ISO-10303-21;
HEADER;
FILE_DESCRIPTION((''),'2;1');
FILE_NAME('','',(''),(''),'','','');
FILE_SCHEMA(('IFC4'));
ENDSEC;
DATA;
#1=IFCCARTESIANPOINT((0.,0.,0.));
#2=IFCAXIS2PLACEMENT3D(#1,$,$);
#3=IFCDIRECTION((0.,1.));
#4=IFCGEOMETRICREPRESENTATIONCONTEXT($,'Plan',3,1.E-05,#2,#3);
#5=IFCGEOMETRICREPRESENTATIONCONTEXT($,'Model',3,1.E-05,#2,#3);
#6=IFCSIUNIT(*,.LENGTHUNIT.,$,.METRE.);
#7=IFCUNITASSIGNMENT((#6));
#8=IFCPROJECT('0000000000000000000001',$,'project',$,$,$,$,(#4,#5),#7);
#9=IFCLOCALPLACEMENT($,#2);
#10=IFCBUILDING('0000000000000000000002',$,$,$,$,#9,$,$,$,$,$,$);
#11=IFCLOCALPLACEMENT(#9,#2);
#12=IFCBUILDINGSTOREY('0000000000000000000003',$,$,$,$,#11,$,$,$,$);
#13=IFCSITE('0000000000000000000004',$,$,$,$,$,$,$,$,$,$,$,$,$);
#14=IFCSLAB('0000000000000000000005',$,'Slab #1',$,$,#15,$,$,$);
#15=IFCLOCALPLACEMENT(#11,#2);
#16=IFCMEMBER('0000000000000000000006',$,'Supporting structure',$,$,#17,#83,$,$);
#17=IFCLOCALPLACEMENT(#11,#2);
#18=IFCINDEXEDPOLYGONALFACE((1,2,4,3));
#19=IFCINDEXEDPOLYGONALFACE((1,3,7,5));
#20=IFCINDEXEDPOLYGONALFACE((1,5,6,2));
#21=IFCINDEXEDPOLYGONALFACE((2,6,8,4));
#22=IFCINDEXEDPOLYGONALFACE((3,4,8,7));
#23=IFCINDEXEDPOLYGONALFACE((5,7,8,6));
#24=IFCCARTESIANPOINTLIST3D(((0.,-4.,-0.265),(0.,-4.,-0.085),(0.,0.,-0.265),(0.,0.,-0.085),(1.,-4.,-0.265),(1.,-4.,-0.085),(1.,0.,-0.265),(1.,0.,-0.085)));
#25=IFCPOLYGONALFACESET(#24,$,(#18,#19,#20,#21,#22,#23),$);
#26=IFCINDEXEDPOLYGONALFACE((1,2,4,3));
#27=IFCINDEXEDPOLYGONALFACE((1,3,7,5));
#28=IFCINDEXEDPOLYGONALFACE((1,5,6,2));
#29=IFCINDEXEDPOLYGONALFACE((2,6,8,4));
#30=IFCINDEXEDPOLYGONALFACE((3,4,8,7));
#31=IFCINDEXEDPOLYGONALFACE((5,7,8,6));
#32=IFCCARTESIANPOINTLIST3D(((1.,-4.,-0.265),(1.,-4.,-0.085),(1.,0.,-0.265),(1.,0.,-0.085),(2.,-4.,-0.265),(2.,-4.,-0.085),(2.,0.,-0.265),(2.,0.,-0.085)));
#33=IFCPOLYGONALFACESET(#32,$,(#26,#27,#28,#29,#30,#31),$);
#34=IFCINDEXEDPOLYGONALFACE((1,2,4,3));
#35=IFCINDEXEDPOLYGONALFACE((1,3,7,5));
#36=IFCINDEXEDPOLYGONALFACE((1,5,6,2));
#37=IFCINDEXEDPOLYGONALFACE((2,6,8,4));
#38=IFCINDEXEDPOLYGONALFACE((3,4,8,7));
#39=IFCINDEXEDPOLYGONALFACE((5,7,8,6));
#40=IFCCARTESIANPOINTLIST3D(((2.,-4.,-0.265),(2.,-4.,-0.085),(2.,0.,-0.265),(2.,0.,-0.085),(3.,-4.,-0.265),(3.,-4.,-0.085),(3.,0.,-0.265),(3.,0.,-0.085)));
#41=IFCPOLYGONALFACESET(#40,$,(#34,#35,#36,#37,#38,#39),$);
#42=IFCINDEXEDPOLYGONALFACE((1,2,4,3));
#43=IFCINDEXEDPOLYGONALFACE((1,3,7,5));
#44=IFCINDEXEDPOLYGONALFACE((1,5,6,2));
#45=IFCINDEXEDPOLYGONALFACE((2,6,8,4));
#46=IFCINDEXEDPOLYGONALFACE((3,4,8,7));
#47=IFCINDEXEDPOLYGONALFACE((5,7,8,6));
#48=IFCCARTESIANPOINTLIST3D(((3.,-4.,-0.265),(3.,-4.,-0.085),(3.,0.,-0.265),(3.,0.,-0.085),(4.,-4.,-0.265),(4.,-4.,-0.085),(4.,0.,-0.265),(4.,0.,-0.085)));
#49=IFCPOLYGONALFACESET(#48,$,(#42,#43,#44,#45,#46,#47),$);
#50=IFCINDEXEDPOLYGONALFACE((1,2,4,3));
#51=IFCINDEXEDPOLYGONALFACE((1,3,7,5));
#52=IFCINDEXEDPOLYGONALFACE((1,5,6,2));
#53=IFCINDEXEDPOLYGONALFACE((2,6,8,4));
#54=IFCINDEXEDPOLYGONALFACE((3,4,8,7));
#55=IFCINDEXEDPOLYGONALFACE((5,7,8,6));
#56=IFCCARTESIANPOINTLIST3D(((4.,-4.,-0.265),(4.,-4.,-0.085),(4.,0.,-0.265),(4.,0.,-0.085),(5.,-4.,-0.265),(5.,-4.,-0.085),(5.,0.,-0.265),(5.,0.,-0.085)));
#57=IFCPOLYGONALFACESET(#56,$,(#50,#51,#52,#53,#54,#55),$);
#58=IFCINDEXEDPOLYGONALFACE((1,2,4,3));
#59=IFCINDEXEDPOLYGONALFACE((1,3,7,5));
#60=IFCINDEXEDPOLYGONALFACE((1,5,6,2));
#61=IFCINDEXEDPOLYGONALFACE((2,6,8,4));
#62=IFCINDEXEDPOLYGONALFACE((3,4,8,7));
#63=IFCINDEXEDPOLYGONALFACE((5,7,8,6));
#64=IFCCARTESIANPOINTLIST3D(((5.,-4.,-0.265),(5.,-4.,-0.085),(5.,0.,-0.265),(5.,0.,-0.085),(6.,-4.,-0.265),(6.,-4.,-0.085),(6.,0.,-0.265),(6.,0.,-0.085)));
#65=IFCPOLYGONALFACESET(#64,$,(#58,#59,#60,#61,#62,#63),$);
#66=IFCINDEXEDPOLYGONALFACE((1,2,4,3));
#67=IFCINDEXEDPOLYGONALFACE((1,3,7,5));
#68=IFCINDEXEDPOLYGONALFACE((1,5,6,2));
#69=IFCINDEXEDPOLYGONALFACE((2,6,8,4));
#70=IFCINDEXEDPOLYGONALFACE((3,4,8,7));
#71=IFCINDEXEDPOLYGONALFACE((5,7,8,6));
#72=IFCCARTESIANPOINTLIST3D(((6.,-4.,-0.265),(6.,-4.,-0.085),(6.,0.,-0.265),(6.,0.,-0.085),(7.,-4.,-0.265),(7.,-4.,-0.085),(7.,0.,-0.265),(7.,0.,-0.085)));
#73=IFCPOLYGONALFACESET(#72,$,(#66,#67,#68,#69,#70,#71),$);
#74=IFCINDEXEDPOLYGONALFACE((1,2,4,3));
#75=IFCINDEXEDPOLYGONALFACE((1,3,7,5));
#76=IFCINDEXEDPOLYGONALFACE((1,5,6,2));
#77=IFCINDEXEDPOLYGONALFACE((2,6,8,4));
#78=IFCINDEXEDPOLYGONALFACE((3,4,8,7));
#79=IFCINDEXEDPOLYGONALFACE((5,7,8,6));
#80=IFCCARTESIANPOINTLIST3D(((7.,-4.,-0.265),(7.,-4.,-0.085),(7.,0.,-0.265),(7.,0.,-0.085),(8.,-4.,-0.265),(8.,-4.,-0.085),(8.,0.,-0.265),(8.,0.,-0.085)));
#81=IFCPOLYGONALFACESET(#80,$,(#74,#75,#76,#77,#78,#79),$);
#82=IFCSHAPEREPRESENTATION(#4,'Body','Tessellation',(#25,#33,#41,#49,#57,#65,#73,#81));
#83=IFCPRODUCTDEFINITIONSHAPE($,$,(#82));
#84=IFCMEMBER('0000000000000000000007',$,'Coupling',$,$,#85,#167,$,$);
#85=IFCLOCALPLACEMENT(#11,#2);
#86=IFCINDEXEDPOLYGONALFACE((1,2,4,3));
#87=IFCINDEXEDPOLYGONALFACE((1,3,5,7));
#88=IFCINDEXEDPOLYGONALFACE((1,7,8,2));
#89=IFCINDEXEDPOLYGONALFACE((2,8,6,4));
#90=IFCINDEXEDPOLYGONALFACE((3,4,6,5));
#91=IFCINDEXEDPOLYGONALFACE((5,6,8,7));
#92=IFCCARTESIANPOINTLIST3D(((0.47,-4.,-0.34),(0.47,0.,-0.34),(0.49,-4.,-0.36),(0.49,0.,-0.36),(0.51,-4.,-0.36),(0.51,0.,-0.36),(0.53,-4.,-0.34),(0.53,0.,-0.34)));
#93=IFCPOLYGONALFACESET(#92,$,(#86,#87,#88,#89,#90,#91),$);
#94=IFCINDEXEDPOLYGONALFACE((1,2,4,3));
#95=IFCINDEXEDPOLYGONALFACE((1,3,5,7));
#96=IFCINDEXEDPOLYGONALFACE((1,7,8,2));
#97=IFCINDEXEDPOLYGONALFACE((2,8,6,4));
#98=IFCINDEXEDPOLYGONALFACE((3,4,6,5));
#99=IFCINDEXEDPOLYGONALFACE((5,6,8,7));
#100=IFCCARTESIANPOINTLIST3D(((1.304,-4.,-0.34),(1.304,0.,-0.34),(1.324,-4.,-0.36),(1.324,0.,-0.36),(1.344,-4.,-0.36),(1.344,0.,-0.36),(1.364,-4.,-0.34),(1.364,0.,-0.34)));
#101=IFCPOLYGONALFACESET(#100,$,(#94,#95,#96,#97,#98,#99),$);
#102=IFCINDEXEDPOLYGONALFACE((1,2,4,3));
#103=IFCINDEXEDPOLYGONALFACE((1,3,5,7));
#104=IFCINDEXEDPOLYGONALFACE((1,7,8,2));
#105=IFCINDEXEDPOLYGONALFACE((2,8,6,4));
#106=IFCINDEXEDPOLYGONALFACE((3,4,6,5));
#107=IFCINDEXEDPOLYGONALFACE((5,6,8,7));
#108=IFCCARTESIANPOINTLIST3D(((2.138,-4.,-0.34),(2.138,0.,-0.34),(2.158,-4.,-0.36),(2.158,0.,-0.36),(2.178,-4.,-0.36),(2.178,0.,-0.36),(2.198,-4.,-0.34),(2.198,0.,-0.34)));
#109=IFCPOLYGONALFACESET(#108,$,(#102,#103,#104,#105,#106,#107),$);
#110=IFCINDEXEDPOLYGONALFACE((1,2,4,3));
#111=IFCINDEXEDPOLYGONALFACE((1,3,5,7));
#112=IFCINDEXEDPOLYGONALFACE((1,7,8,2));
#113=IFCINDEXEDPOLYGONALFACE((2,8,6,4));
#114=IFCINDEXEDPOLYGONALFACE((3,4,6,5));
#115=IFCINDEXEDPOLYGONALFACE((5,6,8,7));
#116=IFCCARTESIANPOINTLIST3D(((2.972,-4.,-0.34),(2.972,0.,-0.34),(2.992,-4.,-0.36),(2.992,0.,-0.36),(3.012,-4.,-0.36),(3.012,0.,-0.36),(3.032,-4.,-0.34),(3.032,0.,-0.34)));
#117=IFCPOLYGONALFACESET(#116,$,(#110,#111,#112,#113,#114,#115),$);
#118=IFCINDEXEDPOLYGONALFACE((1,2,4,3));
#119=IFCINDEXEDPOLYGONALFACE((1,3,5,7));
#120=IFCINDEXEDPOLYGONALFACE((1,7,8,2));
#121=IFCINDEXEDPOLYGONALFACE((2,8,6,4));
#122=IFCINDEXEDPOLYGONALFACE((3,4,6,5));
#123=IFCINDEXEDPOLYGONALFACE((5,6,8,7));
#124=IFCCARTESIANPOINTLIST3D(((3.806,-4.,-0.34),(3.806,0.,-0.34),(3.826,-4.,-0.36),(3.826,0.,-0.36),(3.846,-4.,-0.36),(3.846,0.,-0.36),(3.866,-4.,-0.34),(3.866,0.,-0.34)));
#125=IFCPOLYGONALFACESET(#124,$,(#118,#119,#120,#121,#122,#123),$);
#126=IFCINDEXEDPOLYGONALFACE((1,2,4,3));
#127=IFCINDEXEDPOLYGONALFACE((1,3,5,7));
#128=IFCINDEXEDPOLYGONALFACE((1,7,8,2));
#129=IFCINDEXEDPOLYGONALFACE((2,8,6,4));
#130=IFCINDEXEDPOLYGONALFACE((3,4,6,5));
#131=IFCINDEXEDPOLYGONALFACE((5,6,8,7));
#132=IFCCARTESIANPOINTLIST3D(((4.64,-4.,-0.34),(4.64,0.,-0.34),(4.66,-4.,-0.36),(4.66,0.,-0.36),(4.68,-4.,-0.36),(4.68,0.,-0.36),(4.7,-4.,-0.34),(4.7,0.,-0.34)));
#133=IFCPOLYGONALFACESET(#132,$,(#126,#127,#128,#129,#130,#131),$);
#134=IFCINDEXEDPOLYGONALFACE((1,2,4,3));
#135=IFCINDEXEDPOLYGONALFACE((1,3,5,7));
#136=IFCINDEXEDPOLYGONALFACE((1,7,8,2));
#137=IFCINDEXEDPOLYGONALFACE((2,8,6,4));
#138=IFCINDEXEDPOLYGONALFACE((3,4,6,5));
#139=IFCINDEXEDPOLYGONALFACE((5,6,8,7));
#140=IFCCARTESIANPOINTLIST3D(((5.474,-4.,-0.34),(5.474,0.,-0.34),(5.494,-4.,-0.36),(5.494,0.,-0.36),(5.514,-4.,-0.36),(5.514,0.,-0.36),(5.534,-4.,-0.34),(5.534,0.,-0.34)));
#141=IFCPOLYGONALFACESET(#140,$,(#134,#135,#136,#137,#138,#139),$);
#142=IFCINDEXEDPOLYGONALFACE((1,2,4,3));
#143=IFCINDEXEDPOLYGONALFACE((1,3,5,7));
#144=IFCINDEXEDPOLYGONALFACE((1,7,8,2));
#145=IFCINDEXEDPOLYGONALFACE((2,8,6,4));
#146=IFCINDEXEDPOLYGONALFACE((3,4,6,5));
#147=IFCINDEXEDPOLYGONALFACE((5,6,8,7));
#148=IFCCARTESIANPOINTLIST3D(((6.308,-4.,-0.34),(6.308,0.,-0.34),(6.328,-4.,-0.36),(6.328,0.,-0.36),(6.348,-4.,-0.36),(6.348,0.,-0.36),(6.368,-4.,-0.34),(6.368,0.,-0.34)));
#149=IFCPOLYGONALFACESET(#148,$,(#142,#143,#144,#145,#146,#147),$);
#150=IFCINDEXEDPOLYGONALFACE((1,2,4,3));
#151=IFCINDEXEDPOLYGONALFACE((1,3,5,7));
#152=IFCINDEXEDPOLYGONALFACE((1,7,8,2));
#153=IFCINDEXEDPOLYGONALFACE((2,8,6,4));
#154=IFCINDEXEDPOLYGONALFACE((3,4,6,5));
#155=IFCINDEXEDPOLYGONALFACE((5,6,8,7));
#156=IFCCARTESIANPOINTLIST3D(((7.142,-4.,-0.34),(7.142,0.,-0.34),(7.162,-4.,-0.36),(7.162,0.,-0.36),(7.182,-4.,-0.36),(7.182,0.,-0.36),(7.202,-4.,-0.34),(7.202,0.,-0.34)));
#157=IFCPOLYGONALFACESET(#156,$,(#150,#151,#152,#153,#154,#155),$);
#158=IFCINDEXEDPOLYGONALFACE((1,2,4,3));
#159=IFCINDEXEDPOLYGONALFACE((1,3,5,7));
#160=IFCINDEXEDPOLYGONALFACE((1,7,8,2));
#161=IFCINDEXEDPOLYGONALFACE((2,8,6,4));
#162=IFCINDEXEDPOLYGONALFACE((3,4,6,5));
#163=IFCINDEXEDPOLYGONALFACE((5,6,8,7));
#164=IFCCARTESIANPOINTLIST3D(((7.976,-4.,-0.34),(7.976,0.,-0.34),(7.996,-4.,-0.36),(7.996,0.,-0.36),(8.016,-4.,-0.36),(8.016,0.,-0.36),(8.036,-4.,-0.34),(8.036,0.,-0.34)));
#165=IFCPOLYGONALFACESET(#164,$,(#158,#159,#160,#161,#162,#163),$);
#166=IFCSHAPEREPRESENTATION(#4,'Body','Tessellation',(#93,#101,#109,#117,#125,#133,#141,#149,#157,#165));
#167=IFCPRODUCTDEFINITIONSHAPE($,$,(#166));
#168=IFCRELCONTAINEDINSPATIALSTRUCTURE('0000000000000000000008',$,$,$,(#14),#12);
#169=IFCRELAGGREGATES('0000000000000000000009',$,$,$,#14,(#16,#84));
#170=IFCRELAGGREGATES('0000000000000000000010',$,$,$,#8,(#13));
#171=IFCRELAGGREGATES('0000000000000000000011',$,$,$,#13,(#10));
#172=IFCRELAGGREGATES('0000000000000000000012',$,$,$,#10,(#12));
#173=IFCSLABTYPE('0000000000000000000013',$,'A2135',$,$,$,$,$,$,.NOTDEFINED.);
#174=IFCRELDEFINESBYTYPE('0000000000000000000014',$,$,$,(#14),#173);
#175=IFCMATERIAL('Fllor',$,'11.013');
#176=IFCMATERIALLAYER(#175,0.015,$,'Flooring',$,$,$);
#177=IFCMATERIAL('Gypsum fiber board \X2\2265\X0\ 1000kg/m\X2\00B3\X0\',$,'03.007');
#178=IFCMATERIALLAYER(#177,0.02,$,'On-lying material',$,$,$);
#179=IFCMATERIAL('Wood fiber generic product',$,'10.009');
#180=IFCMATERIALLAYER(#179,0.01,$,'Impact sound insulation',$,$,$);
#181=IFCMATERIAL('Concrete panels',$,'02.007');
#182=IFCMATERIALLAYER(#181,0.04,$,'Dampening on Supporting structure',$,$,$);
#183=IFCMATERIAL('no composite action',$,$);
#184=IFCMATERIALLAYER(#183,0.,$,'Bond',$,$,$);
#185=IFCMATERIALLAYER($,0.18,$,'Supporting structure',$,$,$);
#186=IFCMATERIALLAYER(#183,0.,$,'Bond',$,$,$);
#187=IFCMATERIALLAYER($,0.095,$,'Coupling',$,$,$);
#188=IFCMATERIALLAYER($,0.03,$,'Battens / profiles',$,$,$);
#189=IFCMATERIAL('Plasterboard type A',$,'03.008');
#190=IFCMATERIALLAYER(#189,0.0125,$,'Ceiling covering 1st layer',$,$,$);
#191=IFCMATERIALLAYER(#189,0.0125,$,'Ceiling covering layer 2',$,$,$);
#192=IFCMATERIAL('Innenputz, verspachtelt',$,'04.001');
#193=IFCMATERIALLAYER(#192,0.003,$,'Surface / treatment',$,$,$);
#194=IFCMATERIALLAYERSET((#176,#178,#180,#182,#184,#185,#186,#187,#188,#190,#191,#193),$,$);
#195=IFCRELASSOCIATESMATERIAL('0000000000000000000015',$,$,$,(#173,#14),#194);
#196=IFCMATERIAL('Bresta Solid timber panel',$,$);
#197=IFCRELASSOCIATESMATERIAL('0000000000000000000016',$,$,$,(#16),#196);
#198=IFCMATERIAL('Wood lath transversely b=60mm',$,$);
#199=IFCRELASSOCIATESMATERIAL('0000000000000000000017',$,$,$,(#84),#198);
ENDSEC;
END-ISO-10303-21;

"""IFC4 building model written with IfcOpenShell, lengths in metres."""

from ifc_helpers import new_model, si_unit, direction, frame, frame_2d, origin, place, context, project, spatial, polyline, rectangle, outline, extrude, material, layer, layer_set, type_object, element, aggregate, save


model = new_model("IFC4")

# Units and contexts
plan_context = context("Plan", 3, precision=1e-05, world=origin(), true_north=direction((0.0, 1.0)))
model_context = context("Model", 3, precision=1e-05, world=origin(), true_north=direction((0.0, 1.0)))
ifc_project = project(units=[si_unit("LENGTHUNIT", "METRE")], contexts=[plan_context, model_context])

# Site, building, storey
site = spatial("IfcSite", under=ifc_project)
building_placement = place(None, origin())
building = spatial("IfcBuilding", under=site, at=building_placement)
storey_placement = place(building_placement, origin())
storey = spatial("IfcBuildingStorey", under=building, at=storey_placement)

# Slab, members
ifc_material_1 = material(Name="Fllor", Category="11.013")
ifc_layer_1 = layer(ifc_material_1, 0.015, Name="Flooring")
ifc_material_2 = material(Name="Gypsum fiber board ≥ 1000kg/m³", Category="03.007")
ifc_layer_2 = layer(ifc_material_2, 0.02, Name="On-lying material")
ifc_material_3 = material(Name="Wood fiber generic product", Category="10.009")
ifc_layer_3 = layer(ifc_material_3, 0.01, Name="Impact sound insulation")
ifc_material_4 = material(Name="Concrete panels", Category="02.007")
ifc_layer_4 = layer(ifc_material_4, 0.04, Name="Dampening on Supporting structure")
ifc_material_5 = material(Name="no composite action")
ifc_layer_5 = layer(ifc_material_5, 0.0, Name="Bond")
ifc_layer_6 = layer(None, 0.18, Name="Supporting structure")
ifc_layer_7 = layer(ifc_material_5, 0.0, Name="Bond")
ifc_layer_8 = layer(None, 0.095, Name="Coupling")
ifc_layer_9 = layer(None, 0.03, Name="Battens / profiles")
ifc_material_6 = material(Name="Plasterboard type A", Category="03.008")
ifc_layer_10 = layer(ifc_material_6, 0.0125, Name="Ceiling covering 1st layer")
ifc_layer_11 = layer(ifc_material_6, 0.0125, Name="Ceiling covering layer 2")
ifc_material_7 = material(Name="Innenputz, verspachtelt", Category="04.001")
ifc_layer_12 = layer(ifc_material_7, 0.003, Name="Surface / treatment")
ifc_layer_set = layer_set([ifc_layer_1, ifc_layer_2, ifc_layer_3, ifc_layer_4, ifc_layer_5, ifc_layer_6, ifc_layer_7, ifc_layer_8, ifc_layer_9, ifc_layer_10, ifc_layer_11, ifc_layer_12])
slab_type = type_object("IfcSlabType", Name="A2135", PredefinedType="NOTDEFINED", material=ifc_layer_set)
slab_placement = place(None, frame((0.0, 0.0, 0.0), z_axis=(0.0, 0.0, -1.0), x_axis=(1.0, 0.0, 0.0)))
slab = element("IfcSlab", 1, at=slab_placement, inside=storey, type_object=slab_type, material=ifc_layer_set, Name="Slab #1")
ifc_material_8 = material(Name="Bresta Solid timber panel")
member_1_placement = place(slab_placement, origin())
member_1 = element("IfcMember", 2, at=member_1_placement, material=ifc_material_8, Name="Supporting structure", context=plan_context, shape_type="SweptSolid", body=[
    extrude(rectangle(XDim=1.0, YDim=0.18, at=frame_2d((0.5, 0.09), x_axis=(1.0, 0.0))), frame((0.0, 4.0, 0.085), z_axis=(0.0, -1.0, 0.0), x_axis=(1.0, 0.0, 0.0)), (0.0, 0.0, 1.0), 4.0),
    extrude(rectangle(XDim=1.0, YDim=0.18, at=frame_2d((0.5, 0.09), x_axis=(1.0, 0.0))), frame((1.0, 4.0, 0.085), z_axis=(0.0, -1.0, 0.0), x_axis=(1.0, 0.0, 0.0)), (0.0, 0.0, 1.0), 4.0),
    extrude(rectangle(XDim=1.0, YDim=0.18, at=frame_2d((0.5, 0.09), x_axis=(1.0, 0.0))), frame((2.0, 4.0, 0.085), z_axis=(0.0, -1.0, 0.0), x_axis=(1.0, 0.0, 0.0)), (0.0, 0.0, 1.0), 4.0),
    extrude(rectangle(XDim=1.0, YDim=0.18, at=frame_2d((0.5, 0.09), x_axis=(1.0, 0.0))), frame((3.0, 4.0, 0.085), z_axis=(0.0, -1.0, 0.0), x_axis=(1.0, 0.0, 0.0)), (0.0, 0.0, 1.0), 4.0),
    extrude(rectangle(XDim=1.0, YDim=0.18, at=frame_2d((0.5, 0.09), x_axis=(1.0, 0.0))), frame((4.0, 4.0, 0.085), z_axis=(0.0, -1.0, 0.0), x_axis=(1.0, 0.0, 0.0)), (0.0, 0.0, 1.0), 4.0),
    extrude(rectangle(XDim=1.0, YDim=0.18, at=frame_2d((0.5, 0.09), x_axis=(1.0, 0.0))), frame((5.0, 4.0, 0.085), z_axis=(0.0, -1.0, 0.0), x_axis=(1.0, 0.0, 0.0)), (0.0, 0.0, 1.0), 4.0),
    extrude(rectangle(XDim=1.0, YDim=0.18, at=frame_2d((0.5, 0.09), x_axis=(1.0, 0.0))), frame((6.0, 4.0, 0.085), z_axis=(0.0, -1.0, 0.0), x_axis=(1.0, 0.0, 0.0)), (0.0, 0.0, 1.0), 4.0),
    extrude(rectangle(XDim=1.0, YDim=0.18, at=frame_2d((0.5, 0.09), x_axis=(1.0, 0.0))), frame((7.0, 4.0, 0.085), z_axis=(0.0, -1.0, 0.0), x_axis=(1.0, 0.0, 0.0)), (0.0, 0.0, 1.0), 4.0),
])
ifc_material_9 = material(Name="Wood lath transversely b=60mm")
member_2_placement = place(slab_placement, origin())
member_2 = element("IfcMember", 3, at=member_2_placement, material=ifc_material_9, Name="Coupling", context=plan_context, shape_type="SweptSolid", body=[
    extrude(outline(polyline([(0.0, 0.0), (0.06, 0.0), (0.04, 0.02), (0.02, 0.02), (0.0, 0.0)])), frame((0.47, 4.0, 0.34), z_axis=(0.0, -1.0, 0.0), x_axis=(1.0, 0.0, 0.0)), (0.0, 0.0, 1.0), 4.0),
    extrude(outline(polyline([(0.0, 0.0), (0.06, 0.0), (0.04, 0.02), (0.02, 0.02), (0.0, 0.0)])), frame((1.304, 4.0, 0.34), z_axis=(0.0, -1.0, 0.0), x_axis=(1.0, 0.0, 0.0)), (0.0, 0.0, 1.0), 4.0),
    extrude(outline(polyline([(0.0, 0.0), (0.06, 0.0), (0.04, 0.02), (0.02, 0.02), (0.0, 0.0)])), frame((2.138, 4.0, 0.34), z_axis=(0.0, -1.0, 0.0), x_axis=(1.0, 0.0, 0.0)), (0.0, 0.0, 1.0), 4.0),
    extrude(outline(polyline([(0.0, 0.0), (0.06, 0.0), (0.04, 0.02), (0.02, 0.02), (0.0, 0.0)])), frame((2.972, 4.0, 0.34), z_axis=(0.0, -1.0, 0.0), x_axis=(1.0, 0.0, 0.0)), (0.0, 0.0, 1.0), 4.0),
    extrude(outline(polyline([(0.0, 0.0), (0.06, 0.0), (0.04, 0.02), (0.02, 0.02), (0.0, 0.0)])), frame((3.806, 4.0, 0.34), z_axis=(0.0, -1.0, 0.0), x_axis=(1.0, 0.0, 0.0)), (0.0, 0.0, 1.0), 4.0),
    extrude(outline(polyline([(0.0, 0.0), (0.06, 0.0), (0.04, 0.02), (0.02, 0.02), (0.0, 0.0)])), frame((4.64, 4.0, 0.34), z_axis=(0.0, -1.0, 0.0), x_axis=(1.0, 0.0, 0.0)), (0.0, 0.0, 1.0), 4.0),
    extrude(outline(polyline([(0.0, 0.0), (0.06, 0.0), (0.04, 0.02), (0.02, 0.02), (0.0, 0.0)])), frame((5.474, 4.0, 0.34), z_axis=(0.0, -1.0, 0.0), x_axis=(1.0, 0.0, 0.0)), (0.0, 0.0, 1.0), 4.0),
    extrude(outline(polyline([(0.0, 0.0), (0.06, 0.0), (0.04, 0.02), (0.02, 0.02), (0.0, 0.0)])), frame((6.308, 4.0, 0.34), z_axis=(0.0, -1.0, 0.0), x_axis=(1.0, 0.0, 0.0)), (0.0, 0.0, 1.0), 4.0),
    extrude(outline(polyline([(0.0, 0.0), (0.06, 0.0), (0.04, 0.02), (0.02, 0.02), (0.0, 0.0)])), frame((7.142, 4.0, 0.34), z_axis=(0.0, -1.0, 0.0), x_axis=(1.0, 0.0, 0.0)), (0.0, 0.0, 1.0), 4.0),
    extrude(outline(polyline([(0.0, 0.0), (0.06, 0.0), (0.04, 0.02), (0.02, 0.02), (0.0, 0.0)])), frame((7.976, 4.0, 0.34), z_axis=(0.0, -1.0, 0.0), x_axis=(1.0, 0.0, 0.0)), (0.0, 0.0, 1.0), 4.0),
])
aggregate(slab, [member_1, member_2])

save(model, "model.ifc")
